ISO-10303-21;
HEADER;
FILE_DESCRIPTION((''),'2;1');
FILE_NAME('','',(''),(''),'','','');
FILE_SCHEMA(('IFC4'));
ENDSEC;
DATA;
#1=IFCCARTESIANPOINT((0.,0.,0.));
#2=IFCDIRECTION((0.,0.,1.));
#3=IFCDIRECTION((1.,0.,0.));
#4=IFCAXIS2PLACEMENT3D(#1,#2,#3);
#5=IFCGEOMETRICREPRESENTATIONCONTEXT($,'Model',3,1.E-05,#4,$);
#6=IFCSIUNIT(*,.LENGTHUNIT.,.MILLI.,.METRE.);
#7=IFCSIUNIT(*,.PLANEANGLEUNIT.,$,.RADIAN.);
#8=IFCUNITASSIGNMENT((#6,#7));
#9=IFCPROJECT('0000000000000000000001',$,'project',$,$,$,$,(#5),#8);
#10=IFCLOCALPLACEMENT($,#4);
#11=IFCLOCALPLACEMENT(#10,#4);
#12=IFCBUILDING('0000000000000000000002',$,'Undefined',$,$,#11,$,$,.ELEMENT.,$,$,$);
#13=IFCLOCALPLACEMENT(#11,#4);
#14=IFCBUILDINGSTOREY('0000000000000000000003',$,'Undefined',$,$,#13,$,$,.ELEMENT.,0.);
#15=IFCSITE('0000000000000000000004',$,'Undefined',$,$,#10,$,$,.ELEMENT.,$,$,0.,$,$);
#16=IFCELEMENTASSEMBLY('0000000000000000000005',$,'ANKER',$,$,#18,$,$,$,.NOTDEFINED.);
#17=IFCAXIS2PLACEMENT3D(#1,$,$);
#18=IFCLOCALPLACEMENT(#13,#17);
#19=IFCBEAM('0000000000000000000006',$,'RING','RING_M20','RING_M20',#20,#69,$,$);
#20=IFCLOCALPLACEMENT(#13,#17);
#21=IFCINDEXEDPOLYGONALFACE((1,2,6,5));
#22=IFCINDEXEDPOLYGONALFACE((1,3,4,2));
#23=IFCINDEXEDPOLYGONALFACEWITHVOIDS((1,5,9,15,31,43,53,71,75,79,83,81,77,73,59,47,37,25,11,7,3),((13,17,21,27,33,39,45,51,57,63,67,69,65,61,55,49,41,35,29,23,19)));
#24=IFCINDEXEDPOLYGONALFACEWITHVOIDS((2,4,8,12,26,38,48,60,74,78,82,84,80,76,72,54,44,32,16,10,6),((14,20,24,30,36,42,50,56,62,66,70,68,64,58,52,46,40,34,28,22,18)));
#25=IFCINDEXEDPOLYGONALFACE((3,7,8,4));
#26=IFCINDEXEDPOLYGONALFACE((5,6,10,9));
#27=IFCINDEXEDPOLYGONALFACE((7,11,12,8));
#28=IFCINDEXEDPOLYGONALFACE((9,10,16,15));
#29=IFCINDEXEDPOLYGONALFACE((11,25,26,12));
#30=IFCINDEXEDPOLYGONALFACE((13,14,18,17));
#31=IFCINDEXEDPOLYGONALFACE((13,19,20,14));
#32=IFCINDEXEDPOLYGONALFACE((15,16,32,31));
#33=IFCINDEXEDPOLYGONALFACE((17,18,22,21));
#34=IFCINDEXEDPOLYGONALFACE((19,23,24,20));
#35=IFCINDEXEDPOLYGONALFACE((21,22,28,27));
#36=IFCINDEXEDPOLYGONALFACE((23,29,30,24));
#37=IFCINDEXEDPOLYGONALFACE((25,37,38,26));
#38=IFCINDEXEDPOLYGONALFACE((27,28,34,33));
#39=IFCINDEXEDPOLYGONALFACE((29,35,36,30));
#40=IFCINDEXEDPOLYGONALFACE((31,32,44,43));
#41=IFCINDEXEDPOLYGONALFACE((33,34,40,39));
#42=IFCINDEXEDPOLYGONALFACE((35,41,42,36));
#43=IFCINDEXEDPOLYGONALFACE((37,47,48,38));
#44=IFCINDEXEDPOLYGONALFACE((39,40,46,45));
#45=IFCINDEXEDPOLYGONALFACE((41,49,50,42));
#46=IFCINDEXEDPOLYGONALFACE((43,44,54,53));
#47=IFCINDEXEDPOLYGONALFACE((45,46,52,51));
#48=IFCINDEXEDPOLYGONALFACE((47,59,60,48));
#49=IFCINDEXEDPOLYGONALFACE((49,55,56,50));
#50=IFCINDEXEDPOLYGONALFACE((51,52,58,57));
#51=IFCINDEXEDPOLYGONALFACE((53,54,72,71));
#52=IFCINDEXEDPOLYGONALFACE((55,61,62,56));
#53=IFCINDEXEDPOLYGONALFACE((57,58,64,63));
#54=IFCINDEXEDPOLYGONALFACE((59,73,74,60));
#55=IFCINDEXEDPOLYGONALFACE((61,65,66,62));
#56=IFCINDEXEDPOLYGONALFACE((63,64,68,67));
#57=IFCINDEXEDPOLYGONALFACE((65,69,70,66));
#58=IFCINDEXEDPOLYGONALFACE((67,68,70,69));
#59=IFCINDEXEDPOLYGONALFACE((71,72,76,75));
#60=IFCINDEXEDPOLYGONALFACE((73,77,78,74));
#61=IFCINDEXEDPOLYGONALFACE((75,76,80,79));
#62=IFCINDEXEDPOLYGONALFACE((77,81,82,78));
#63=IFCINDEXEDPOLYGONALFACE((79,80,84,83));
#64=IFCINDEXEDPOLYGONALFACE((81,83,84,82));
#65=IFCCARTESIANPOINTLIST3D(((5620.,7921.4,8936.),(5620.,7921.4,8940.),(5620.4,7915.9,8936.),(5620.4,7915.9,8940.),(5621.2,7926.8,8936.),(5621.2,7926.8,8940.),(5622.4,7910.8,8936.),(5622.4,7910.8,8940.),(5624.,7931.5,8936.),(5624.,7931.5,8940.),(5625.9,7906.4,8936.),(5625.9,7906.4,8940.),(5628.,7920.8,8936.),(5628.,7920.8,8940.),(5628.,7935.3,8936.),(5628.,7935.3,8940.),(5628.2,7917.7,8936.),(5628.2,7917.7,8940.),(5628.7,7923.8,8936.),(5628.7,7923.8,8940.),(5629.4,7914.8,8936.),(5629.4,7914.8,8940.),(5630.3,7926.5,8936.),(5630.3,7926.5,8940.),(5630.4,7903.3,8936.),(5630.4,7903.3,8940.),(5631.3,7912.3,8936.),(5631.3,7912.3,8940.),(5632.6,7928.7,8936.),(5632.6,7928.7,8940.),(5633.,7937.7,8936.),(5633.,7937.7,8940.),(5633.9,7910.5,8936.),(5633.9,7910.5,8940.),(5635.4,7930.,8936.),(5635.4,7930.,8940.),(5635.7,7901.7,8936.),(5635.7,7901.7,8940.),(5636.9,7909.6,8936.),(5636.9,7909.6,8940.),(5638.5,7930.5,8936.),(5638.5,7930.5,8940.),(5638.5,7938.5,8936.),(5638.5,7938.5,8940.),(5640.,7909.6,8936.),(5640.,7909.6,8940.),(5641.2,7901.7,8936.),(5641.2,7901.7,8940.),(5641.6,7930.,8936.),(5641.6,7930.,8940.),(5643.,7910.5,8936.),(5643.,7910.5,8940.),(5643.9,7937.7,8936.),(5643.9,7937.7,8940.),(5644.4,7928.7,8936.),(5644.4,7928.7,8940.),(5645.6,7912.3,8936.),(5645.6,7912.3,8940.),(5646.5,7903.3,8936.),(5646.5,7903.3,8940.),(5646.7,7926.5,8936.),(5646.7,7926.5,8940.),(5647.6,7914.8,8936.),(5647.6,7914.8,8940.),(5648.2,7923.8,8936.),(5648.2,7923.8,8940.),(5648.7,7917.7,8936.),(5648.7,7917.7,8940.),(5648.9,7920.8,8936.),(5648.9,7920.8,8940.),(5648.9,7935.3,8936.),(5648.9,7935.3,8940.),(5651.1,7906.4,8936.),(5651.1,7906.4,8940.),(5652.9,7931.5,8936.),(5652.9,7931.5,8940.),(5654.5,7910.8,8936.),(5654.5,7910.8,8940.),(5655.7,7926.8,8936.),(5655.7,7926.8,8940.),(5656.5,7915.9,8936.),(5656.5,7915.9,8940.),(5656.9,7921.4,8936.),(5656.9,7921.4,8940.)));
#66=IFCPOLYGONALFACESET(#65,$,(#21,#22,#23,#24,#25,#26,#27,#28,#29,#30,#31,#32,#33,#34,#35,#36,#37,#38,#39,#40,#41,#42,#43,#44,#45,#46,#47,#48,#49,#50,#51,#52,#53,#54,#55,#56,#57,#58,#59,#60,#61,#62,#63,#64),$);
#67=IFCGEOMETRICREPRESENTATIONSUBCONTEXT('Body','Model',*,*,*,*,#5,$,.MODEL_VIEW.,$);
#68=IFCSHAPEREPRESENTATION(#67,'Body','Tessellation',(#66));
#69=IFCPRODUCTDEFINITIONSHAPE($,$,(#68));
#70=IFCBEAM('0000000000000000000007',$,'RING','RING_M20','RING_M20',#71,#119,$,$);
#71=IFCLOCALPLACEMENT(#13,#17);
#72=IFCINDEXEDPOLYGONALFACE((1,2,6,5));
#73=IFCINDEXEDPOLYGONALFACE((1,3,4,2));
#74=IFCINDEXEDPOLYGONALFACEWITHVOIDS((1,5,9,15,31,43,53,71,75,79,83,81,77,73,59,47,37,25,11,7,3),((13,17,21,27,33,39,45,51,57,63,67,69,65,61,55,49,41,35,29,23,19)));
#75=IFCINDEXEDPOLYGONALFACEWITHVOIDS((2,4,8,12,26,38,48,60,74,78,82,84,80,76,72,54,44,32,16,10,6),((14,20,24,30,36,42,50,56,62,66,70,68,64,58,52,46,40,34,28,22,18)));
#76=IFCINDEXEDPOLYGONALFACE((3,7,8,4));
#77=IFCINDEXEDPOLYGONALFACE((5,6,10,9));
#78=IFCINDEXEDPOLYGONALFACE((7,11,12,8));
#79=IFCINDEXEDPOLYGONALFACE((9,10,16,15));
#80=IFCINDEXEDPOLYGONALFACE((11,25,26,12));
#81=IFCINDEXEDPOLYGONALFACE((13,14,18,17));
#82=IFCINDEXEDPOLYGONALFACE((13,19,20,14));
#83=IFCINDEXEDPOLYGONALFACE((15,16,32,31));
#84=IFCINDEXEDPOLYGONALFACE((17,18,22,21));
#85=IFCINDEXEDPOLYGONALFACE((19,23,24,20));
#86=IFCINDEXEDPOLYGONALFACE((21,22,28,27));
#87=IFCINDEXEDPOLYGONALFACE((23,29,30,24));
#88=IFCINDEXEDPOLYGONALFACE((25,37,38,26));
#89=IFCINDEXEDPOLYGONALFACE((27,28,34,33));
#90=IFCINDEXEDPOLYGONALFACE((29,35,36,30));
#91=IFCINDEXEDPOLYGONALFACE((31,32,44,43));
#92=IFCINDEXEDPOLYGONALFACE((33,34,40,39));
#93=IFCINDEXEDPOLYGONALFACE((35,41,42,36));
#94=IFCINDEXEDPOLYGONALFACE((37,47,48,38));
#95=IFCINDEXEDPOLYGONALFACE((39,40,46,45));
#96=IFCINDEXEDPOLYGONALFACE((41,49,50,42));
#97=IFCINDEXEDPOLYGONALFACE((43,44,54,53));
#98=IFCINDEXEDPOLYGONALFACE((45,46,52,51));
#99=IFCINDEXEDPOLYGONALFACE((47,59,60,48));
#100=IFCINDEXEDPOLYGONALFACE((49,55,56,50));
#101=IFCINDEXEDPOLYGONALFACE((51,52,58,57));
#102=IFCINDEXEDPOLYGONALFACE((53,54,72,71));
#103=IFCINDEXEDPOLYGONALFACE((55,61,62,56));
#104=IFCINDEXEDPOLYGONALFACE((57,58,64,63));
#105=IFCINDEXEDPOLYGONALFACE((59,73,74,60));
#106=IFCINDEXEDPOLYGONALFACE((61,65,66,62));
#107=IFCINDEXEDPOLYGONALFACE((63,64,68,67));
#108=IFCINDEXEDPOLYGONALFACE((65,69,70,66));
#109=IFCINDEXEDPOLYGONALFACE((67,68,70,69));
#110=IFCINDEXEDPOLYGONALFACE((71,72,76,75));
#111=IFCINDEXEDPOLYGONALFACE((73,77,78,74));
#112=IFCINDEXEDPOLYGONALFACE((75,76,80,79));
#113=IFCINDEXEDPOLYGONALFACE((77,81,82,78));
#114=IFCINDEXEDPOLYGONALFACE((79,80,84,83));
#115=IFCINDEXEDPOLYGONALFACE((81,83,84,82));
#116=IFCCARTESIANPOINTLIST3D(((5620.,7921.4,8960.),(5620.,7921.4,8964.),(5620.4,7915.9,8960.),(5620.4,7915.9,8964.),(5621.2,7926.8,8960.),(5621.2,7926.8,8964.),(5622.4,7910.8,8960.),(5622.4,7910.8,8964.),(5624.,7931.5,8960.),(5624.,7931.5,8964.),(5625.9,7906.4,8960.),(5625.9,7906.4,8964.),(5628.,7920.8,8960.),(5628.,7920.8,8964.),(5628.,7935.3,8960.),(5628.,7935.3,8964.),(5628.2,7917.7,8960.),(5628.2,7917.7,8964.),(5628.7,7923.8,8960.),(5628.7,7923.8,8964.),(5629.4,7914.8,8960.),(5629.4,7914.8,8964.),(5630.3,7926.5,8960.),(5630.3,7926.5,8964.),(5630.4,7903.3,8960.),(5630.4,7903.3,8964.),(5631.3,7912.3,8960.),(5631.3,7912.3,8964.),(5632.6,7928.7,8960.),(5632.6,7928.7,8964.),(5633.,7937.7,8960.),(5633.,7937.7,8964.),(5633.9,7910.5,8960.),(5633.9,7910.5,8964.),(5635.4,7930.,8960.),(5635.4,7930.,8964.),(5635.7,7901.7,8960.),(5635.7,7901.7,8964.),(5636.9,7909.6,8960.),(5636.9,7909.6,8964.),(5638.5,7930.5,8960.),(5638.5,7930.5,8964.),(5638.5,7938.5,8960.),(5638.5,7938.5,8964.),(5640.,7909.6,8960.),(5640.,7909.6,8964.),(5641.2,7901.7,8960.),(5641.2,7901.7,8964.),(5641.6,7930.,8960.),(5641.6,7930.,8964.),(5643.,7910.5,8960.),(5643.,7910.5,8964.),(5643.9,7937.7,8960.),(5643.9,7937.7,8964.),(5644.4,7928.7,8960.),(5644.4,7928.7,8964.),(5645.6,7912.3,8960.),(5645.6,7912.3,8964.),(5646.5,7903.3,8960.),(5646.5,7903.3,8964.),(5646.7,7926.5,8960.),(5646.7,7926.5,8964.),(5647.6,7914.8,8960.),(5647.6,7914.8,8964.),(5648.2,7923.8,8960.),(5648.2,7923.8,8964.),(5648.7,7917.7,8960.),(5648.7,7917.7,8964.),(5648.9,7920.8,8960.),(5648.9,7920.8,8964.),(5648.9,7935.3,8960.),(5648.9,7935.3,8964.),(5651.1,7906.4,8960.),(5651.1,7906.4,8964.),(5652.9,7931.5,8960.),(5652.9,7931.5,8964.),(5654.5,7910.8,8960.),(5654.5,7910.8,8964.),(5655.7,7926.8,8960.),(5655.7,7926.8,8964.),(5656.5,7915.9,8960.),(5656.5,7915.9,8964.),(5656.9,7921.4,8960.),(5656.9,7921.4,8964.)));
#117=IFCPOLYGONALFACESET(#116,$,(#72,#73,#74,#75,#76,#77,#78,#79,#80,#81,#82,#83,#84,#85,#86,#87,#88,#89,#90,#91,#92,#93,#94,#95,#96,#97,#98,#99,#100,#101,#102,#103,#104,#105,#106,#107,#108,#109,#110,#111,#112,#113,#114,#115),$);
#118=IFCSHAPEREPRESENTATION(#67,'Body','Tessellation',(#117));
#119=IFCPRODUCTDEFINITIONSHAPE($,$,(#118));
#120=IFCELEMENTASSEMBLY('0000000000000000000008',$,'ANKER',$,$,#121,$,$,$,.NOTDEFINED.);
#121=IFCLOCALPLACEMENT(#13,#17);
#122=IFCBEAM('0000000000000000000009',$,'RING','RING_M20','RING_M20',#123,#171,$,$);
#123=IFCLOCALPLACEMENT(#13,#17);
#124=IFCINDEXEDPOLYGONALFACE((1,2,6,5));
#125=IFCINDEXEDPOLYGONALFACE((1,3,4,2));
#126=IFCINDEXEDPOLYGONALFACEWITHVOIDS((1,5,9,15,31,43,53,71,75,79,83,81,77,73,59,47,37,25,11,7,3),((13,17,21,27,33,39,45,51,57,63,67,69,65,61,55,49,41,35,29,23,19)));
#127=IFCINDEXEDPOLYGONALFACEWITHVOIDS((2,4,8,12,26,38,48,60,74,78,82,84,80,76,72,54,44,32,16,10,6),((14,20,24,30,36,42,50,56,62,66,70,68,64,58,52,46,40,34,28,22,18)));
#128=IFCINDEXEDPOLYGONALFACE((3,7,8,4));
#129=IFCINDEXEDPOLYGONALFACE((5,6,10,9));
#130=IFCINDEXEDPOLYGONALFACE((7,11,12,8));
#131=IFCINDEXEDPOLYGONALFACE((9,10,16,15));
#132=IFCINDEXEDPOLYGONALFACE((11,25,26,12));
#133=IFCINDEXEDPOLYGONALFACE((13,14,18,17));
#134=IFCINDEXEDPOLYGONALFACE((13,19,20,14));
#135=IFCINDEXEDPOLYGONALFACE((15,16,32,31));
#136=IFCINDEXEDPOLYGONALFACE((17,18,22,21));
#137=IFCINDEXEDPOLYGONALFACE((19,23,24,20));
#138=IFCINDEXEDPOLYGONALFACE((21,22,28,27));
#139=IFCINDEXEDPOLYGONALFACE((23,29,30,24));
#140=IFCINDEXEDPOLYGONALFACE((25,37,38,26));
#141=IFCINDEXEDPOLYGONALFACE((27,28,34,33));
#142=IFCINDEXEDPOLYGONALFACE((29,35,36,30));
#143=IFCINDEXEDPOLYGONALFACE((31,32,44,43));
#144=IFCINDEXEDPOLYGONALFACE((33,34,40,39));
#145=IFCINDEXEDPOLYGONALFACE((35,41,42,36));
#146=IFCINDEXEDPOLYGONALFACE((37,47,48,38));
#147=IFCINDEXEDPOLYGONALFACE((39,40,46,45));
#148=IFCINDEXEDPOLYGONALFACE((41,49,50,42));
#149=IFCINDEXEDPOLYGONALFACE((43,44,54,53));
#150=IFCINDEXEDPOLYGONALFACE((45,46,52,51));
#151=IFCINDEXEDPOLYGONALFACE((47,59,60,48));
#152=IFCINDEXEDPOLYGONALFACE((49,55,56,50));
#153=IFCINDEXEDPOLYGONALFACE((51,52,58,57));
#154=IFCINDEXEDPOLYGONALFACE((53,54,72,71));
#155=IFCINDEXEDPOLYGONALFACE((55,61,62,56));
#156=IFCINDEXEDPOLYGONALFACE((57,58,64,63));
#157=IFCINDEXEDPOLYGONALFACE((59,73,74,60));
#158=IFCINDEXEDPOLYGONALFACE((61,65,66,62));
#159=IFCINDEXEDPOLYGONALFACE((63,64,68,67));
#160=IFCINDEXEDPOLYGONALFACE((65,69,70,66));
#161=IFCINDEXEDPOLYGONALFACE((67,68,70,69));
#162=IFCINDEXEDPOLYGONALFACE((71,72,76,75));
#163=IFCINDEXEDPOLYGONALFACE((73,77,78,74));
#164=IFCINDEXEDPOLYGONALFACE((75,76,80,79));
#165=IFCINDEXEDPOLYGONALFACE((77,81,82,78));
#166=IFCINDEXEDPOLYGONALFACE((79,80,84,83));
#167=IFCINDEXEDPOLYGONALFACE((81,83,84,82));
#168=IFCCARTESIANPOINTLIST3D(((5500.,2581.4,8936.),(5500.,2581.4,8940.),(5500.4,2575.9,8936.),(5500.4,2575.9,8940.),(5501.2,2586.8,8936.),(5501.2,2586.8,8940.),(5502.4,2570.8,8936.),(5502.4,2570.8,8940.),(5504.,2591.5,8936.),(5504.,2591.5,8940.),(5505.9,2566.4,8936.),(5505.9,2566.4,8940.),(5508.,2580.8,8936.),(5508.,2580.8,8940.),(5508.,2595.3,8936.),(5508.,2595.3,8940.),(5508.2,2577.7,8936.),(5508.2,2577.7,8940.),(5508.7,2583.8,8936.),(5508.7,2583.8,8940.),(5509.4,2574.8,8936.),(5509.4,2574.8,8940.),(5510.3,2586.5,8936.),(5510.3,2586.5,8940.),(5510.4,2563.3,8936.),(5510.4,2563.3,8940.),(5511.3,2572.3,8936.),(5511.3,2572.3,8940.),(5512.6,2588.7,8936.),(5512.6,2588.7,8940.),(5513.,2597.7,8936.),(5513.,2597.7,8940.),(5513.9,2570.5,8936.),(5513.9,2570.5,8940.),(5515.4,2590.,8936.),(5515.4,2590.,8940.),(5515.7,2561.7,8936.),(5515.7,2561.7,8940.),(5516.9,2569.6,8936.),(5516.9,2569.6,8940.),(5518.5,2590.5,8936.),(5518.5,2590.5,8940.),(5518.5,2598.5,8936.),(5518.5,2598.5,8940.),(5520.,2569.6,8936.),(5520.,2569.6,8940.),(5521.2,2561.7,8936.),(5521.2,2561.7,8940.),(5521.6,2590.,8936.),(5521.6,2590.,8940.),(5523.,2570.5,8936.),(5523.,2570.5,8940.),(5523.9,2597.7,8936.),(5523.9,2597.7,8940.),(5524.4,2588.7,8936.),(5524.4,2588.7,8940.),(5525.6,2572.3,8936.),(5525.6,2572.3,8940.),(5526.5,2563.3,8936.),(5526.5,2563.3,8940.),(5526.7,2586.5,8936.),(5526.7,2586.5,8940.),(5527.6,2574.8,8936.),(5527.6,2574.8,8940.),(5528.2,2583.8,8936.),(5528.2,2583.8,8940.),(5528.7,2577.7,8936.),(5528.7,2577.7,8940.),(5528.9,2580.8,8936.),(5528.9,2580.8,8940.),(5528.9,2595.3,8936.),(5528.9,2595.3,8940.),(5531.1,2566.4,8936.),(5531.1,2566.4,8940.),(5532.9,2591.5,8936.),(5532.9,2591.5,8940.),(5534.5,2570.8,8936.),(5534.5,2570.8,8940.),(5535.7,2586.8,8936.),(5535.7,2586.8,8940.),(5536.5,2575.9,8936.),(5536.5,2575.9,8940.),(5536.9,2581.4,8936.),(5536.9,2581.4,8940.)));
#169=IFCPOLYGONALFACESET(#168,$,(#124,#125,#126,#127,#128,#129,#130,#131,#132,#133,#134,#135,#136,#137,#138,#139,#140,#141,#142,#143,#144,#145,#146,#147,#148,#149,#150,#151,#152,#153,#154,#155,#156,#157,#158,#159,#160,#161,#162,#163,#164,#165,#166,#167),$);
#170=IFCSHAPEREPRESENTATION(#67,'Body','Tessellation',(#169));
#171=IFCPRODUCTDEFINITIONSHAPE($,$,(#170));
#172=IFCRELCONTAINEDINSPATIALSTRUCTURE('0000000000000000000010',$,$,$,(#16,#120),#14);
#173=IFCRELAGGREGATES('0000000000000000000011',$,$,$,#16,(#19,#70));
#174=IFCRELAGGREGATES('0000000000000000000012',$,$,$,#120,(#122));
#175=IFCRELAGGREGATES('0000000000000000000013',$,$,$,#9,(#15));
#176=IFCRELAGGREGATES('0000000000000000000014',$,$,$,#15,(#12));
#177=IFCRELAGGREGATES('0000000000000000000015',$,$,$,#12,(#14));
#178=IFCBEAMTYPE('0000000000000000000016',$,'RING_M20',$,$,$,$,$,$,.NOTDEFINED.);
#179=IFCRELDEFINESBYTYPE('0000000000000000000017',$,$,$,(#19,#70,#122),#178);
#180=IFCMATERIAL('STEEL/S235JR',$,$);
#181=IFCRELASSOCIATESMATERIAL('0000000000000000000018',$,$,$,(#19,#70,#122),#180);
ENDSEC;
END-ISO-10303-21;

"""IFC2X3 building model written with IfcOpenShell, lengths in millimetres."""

from ifc_helpers import new_model, si_unit, frame, origin_with_axes, origin_2d_with_axis, place, context, subcontext, project, spatial, hollow_circle, extrude, material, type_object, element, aggregate, save


model = new_model("IFC2X3")

# Units and contexts
model_context = context("Model", 3, precision=1e-05, world=origin_with_axes())
body_context = subcontext(model_context, "Body", "Model", "MODEL_VIEW")
ifc_project = project(units=[si_unit("LENGTHUNIT", "METRE", prefix="MILLI"), si_unit("PLANEANGLEUNIT", "RADIAN")], contexts=[model_context])

# Site, building, storey
site_placement = place(None, origin_with_axes())
site = spatial("IfcSite", under=ifc_project, at=site_placement, Name="Undefined", CompositionType="ELEMENT", RefElevation=0.0)
building_placement = place(site_placement, origin_with_axes())
building = spatial("IfcBuilding", under=site, at=building_placement, Name="Undefined", CompositionType="ELEMENT")
storey_placement = place(building_placement, origin_with_axes())
storey = spatial("IfcBuildingStorey", under=building, at=storey_placement, Name="Undefined", CompositionType="ELEMENT", Elevation=0.0)

# Shared definitions
ifc_material = material(Name="STEEL/S235JR")

# Shared definitions
beam_type_1 = type_object("IfcBeamType", Name="RING_M20", PredefinedType="NOTDEFINED")

# Element assemblies, beams
assembly_1_placement = place(storey_placement, frame((5638.5, 7920.0, 9010.0), z_axis=(0.0, 1.0, 0.0), x_axis=(0.0, 0.0, -1.0)))
assembly_1 = element("IfcElementAssembly", 1, at=assembly_1_placement, inside=storey, Name="ANKER", PredefinedType="NOTDEFINED")
beam_1_placement = place(storey_placement, frame((5638.5, 7920.0, 8940.0), z_axis=(-1.0, 0.0, 0.0), x_axis=(0.0, 0.0, -1.0)))
beam_1 = element("IfcBeam", 2, at=beam_1_placement, type_object=beam_type_1, material=ifc_material, Name="RING", Description="RING_M20", ObjectType="RING_M20", context=body_context, shape_type="SweptSolid", body=[
    extrude(hollow_circle(Radius=18.5, WallThickness=8.0, at=origin_2d_with_axis()), frame((4.0, 0.0, 0.0), z_axis=(-1.0, 0.0, 0.0), x_axis=(0.0, -1.0, 0.0)), (0.0, 0.0, 1.0), 4.0),
])
beam_2_placement = place(storey_placement, frame((5638.5, 7920.0, 8964.0), z_axis=(-1.0, 0.0, 0.0), x_axis=(0.0, 0.0, -1.0)))
beam_2 = element("IfcBeam", 3, at=beam_2_placement, type_object=beam_type_1, material=ifc_material, Name="RING", Description="RING_M20", ObjectType="RING_M20", context=body_context, shape_type="SweptSolid", body=[
    extrude(hollow_circle(Radius=18.5, WallThickness=8.0, at=origin_2d_with_axis()), frame((4.0, 0.0, 0.0), z_axis=(-1.0, 0.0, 0.0), x_axis=(0.0, -1.0, 0.0)), (0.0, 0.0, 1.0), 4.0),
])
aggregate(assembly_1, [beam_1, beam_2])
assembly_2_placement = place(storey_placement, frame((5518.5, 2580.0, 9010.0), z_axis=(0.0, 1.0, 0.0), x_axis=(0.0, 0.0, -1.0)))
assembly_2 = element("IfcElementAssembly", 4, at=assembly_2_placement, inside=storey, Name="ANKER", PredefinedType="NOTDEFINED")
beam_3_placement = place(storey_placement, frame((5518.5, 2580.0, 8940.0), z_axis=(-1.0, 0.0, 0.0), x_axis=(0.0, 0.0, -1.0)))
beam_3 = element("IfcBeam", 5, at=beam_3_placement, type_object=beam_type_1, material=ifc_material, Name="RING", Description="RING_M20", ObjectType="RING_M20", context=body_context, shape_type="SweptSolid", body=[
    extrude(hollow_circle(Radius=18.5, WallThickness=8.0, at=origin_2d_with_axis()), frame((4.0, 0.0, 0.0), z_axis=(-1.0, 0.0, 0.0), x_axis=(0.0, -1.0, 0.0)), (0.0, 0.0, 1.0), 4.0),
])
aggregate(assembly_2, [beam_3])

save(model, "model.ifc")
